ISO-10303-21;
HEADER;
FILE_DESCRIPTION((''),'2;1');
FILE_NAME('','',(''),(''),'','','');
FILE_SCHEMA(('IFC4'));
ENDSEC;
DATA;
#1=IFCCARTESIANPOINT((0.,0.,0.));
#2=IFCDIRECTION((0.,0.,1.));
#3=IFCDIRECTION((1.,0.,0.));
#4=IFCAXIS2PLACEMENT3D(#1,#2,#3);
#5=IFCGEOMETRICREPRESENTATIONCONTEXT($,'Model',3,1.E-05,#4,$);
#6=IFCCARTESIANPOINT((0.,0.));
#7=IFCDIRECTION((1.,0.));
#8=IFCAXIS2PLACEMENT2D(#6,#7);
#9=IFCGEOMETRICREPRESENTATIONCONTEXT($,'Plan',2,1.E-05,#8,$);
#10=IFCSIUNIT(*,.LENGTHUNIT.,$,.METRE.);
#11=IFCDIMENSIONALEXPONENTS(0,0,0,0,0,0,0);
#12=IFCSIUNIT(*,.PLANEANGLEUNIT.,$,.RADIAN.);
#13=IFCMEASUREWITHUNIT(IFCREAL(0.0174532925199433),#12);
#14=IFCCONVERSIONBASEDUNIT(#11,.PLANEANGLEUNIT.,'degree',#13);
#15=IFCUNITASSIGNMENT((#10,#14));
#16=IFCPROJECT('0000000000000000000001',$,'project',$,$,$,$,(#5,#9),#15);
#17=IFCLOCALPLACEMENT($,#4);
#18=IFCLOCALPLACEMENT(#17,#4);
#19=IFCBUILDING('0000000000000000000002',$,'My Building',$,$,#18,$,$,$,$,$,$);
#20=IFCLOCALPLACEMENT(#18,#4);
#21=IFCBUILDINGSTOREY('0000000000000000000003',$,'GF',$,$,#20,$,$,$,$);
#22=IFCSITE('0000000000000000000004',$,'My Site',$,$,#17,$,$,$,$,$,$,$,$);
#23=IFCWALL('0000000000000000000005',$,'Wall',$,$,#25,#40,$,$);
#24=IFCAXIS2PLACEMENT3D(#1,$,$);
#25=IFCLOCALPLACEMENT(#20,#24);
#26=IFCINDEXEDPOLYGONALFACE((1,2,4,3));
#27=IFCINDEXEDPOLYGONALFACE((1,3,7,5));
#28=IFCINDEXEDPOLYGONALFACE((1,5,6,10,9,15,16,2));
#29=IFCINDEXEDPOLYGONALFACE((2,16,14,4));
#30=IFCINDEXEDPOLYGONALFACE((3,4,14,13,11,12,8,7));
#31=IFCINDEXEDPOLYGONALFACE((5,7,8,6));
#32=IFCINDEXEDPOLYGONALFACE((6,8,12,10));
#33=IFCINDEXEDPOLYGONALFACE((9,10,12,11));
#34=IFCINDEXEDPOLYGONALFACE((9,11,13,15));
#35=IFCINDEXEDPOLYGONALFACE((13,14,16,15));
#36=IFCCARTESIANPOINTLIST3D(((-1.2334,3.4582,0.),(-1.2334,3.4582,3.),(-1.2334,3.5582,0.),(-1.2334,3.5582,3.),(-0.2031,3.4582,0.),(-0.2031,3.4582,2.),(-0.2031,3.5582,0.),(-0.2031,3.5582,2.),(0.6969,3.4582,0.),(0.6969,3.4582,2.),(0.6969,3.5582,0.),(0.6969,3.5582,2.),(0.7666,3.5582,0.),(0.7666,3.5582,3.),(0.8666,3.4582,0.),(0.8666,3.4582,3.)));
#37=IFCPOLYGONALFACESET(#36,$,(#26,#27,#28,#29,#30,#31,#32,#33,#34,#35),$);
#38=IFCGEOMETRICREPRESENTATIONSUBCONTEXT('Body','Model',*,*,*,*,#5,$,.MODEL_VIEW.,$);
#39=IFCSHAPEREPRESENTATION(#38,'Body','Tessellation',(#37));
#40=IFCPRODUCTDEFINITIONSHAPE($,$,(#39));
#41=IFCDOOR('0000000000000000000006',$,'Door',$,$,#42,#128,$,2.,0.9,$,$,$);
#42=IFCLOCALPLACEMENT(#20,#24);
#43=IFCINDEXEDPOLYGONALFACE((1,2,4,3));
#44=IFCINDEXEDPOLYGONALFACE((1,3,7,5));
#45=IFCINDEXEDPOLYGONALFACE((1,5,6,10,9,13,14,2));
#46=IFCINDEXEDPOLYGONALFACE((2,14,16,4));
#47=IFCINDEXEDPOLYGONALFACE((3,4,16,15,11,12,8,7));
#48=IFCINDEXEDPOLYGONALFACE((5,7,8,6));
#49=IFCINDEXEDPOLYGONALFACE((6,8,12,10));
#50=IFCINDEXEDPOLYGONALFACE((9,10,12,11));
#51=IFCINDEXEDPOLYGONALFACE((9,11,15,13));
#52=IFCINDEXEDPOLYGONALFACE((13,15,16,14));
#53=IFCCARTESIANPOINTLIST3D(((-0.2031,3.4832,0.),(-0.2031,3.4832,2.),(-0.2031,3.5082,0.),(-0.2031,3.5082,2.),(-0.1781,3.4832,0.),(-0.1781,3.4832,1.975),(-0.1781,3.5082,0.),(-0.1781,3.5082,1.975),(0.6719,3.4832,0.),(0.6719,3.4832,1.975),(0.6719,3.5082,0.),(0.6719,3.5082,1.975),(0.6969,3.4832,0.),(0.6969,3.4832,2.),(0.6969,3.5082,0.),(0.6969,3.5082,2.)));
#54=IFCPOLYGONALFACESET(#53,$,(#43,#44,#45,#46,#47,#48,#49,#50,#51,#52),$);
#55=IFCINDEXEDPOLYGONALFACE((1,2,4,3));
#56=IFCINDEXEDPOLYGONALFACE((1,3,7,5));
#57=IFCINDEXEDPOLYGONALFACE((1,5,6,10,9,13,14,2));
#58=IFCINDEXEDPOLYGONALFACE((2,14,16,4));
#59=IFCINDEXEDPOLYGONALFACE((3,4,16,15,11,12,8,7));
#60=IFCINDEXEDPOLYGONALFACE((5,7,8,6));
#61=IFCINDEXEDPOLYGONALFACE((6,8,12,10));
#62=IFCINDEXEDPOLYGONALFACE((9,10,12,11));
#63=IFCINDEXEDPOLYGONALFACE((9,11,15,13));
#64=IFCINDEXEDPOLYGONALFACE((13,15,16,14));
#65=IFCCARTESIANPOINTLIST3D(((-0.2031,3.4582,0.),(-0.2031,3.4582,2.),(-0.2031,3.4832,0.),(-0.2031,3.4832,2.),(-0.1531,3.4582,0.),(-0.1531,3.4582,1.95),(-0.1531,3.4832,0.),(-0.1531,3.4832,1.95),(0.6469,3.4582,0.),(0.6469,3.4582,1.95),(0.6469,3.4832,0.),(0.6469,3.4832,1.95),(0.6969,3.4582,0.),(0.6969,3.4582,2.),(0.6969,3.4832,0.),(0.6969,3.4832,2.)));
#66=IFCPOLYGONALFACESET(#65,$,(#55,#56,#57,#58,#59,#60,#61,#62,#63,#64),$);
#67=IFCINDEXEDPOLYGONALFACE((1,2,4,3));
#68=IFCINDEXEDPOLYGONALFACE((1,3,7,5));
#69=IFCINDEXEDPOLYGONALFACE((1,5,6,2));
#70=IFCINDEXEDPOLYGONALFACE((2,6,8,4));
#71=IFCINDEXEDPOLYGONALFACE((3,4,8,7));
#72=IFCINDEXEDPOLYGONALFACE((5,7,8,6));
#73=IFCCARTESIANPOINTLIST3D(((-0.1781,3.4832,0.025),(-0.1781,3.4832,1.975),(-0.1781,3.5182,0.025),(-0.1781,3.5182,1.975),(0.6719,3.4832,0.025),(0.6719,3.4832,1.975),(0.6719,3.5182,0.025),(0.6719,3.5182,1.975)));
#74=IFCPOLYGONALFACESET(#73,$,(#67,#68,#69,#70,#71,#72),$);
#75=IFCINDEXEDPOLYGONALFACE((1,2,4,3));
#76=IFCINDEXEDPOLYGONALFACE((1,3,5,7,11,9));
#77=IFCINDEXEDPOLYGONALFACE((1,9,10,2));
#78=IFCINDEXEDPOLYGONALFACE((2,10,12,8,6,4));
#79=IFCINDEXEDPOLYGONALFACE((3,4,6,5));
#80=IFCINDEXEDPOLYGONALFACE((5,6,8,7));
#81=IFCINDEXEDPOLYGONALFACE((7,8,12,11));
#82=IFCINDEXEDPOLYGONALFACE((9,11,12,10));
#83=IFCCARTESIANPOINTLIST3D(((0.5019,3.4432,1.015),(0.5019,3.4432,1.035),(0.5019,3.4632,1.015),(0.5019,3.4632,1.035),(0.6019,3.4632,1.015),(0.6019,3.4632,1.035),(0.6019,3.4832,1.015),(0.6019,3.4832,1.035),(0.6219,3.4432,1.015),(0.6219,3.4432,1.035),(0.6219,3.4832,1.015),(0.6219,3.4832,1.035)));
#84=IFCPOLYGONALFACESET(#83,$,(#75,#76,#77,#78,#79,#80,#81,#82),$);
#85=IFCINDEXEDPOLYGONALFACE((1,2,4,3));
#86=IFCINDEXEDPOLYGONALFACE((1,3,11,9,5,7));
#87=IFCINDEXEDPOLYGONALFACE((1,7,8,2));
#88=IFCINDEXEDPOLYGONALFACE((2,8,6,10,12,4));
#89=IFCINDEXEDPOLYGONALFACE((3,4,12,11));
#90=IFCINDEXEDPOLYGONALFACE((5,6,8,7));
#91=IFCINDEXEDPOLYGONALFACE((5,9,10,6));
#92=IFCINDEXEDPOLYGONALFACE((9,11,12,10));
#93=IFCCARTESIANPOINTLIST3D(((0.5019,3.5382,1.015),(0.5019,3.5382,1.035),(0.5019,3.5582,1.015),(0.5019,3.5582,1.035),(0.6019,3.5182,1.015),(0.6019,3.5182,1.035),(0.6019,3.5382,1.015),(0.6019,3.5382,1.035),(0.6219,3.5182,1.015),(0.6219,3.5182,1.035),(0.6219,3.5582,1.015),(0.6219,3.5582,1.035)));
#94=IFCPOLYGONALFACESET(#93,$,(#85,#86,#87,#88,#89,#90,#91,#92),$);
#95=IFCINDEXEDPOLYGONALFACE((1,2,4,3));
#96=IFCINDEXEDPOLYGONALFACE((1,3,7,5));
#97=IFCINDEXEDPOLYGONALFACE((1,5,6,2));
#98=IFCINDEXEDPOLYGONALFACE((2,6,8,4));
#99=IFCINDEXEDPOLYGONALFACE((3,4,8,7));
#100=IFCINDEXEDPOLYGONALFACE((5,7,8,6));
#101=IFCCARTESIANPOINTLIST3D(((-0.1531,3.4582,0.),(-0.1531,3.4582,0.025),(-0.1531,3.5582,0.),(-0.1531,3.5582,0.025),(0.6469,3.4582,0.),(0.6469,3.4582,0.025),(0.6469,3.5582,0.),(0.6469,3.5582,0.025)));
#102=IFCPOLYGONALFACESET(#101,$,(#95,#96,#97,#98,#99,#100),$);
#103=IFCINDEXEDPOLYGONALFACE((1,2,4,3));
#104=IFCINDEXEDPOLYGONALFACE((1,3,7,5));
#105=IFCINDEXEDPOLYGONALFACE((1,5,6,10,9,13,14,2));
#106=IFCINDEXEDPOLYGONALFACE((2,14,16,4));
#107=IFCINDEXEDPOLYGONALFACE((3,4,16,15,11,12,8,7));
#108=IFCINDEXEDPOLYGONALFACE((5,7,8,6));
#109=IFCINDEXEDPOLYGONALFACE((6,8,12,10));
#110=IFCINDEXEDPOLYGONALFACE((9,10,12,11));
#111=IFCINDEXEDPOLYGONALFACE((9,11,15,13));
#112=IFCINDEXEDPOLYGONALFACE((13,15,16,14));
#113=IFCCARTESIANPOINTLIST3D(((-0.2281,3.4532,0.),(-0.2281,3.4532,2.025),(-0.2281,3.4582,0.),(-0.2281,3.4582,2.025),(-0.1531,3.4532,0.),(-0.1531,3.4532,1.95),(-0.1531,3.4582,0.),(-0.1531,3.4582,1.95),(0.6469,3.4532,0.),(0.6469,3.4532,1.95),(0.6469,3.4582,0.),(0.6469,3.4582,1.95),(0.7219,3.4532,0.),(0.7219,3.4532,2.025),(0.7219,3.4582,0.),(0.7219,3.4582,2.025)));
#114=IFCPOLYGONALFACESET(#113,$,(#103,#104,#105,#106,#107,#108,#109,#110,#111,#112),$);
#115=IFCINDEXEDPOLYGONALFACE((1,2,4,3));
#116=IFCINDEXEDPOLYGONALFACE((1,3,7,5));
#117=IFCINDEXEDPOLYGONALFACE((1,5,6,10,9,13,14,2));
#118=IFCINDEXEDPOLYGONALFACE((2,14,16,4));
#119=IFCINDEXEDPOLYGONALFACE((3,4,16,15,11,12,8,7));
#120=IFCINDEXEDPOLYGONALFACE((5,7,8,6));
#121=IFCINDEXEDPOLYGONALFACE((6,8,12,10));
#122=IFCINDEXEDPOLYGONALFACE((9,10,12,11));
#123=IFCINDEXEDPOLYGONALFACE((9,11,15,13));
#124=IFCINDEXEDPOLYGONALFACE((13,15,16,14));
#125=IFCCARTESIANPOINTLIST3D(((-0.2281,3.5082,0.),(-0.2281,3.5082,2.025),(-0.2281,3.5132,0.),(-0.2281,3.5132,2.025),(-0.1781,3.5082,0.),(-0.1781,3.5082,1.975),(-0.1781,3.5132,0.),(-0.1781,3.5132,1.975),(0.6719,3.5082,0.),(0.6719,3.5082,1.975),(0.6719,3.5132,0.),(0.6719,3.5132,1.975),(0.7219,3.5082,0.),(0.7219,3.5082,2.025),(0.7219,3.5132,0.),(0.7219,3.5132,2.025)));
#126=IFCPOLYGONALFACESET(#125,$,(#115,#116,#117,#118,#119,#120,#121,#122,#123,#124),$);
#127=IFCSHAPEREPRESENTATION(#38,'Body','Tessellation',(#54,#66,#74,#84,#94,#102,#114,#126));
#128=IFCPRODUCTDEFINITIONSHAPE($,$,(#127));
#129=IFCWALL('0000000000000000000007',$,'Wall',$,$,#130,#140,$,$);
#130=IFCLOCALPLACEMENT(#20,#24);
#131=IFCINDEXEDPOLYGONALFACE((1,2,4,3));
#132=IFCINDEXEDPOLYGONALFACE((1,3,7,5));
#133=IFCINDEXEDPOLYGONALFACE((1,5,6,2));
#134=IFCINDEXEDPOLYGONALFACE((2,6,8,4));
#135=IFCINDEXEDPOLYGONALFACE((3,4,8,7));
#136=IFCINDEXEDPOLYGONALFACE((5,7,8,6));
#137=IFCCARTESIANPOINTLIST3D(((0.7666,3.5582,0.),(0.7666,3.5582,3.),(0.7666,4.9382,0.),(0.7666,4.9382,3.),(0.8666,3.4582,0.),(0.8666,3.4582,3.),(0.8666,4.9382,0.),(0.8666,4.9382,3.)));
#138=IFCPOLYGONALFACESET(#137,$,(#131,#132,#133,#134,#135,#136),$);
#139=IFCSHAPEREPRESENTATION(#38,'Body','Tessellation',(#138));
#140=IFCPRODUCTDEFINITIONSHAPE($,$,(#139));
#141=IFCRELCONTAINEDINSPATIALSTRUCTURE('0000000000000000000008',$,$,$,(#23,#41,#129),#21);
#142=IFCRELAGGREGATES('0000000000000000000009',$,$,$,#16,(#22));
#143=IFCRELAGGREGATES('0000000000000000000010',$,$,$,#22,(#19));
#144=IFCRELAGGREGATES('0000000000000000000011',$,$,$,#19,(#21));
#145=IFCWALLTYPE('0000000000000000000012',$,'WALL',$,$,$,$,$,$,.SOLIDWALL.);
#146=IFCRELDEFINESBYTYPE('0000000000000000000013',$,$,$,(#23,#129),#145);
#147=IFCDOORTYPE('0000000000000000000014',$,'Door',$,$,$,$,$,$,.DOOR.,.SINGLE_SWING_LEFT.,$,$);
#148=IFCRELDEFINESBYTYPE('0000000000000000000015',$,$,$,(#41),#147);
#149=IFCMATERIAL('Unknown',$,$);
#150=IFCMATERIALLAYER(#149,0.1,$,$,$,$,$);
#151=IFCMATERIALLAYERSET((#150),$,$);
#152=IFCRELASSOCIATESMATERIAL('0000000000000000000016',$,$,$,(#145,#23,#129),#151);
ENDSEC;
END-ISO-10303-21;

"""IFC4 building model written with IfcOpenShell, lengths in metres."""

from ifc_helpers import new_model, entity, si_unit, converted_unit, frame, origin_with_axes, origin_2d_with_axis, place, context, subcontext, project, spatial, line, indexed_curve, outline, extrude, shape, source, transform, mapped, material, layer, layer_set, layer_usage, type_object, type_shapes, element, fill, save


model = new_model("IFC4")

# Units and contexts
model_context = context("Model", 3, precision=1e-05, world=origin_with_axes())
plan_context = context("Plan", 2, precision=1e-05, world=origin_2d_with_axis())
body_context_1 = subcontext(model_context, "Body", "Model", "MODEL_VIEW")
body_context_2 = subcontext(plan_context, "Body", "Plan", "PLAN_VIEW")
ifc_project = project(units=[si_unit("LENGTHUNIT", "METRE"), converted_unit("PLANEANGLEUNIT", "degree", entity("IfcReal", 0.0174532925199433), si_unit("PLANEANGLEUNIT", "RADIAN"), dimensions=[0, 0, 0, 0, 0, 0, 0])], contexts=[model_context, plan_context])

# Site, building, storey
site_placement = place(None, origin_with_axes())
site = spatial("IfcSite", under=ifc_project, at=site_placement, Name="My Site")
building_placement = place(site_placement, origin_with_axes())
building = spatial("IfcBuilding", under=site, at=building_placement, Name="My Building")
storey_placement = place(building_placement, origin_with_axes())
storey = spatial("IfcBuildingStorey", under=building, at=storey_placement, Name="GF")

# Shared definitions
ifc_material = material(Name="Unknown")

# Shared definitions
ifc_layer_1 = layer(ifc_material, 0.1)
ifc_layer_set_1 = layer_set([ifc_layer_1])
wall_type = type_object("IfcWallType", Name="WALL", PredefinedType="SOLIDWALL", material=ifc_layer_set_1)
shared_shape_1 = source(origin_with_axes(), body_context_1, "Body", "SweptSolid", [
    extrude(outline(indexed_curve([(0.0, 0.0), (0.9, 0.0), (0.9, 2.0), (0.0, 2.0)], segments=[line(1, 2, 3, 4, 1)])), frame((0.0, -0.6, 0.0), z_axis=(0.0, -1.0, 0.0), x_axis=(1.0, 0.0, 0.0)), (0.0, 0.0, -1.0), 1.2),
])
door_type = type_object("IfcDoorType", Name="Door", OperationType="SINGLE_SWING_LEFT", PredefinedType="DOOR")
shared_shape_2 = source(origin_with_axes(), body_context_1, "Body", "SweptSolid", [
    extrude(outline(indexed_curve([(0.0, 0.0), (0.0, 2.0), (0.9, 2.0), (0.9, 0.0), (0.875, 0.0), (0.875, 1.975), (0.025, 1.975), (0.025, 0.0)], segments=[line(1, 2, 3, 4, 5, 6, 7, 8, 1)])), frame((0.0, 0.025, 0.0), z_axis=(0.0, -1.0, 0.0), x_axis=(1.0, 0.0, 0.0)), (0.0, 0.0, -1.0), 0.025),
    extrude(outline(indexed_curve([(0.0, 0.0), (0.0, 2.0), (0.9, 2.0), (0.9, 0.0), (0.85, 0.0), (0.85, 1.95), (0.05, 1.95), (0.05, 0.0)], segments=[line(1, 2, 3, 4, 5, 6, 7, 8, 1)])), frame((0.0, 0.0, 0.0), z_axis=(0.0, -1.0, 0.0), x_axis=(1.0, 0.0, 0.0)), (0.0, 0.0, -1.0), 0.025),
    extrude(outline(indexed_curve([(0.0, 0.0), (0.85, 0.0), (0.85, 0.035), (0.0, 0.035)], segments=[line(1, 2, 3, 4, 1)])), frame((0.025, 0.025, 0.025), z_axis=(0.0, 0.0, 1.0), x_axis=(1.0, 0.0, 0.0)), (0.0, 0.0, 1.0), 1.95),
    extrude(outline(indexed_curve([(0.0, 0.0), (0.0, -0.04), (-0.12, -0.04), (-0.12, -0.02), (-0.02, -0.02), (-0.02, 0.0)], segments=[line(1, 2, 3, 4, 5, 6, 1)])), frame((0.825, 0.025, 1.015), z_axis=(0.0, 0.0, 1.0), x_axis=(1.0, 0.0, 0.0)), (0.0, 0.0, 1.0), 0.02),
    extrude(outline(indexed_curve([(0.0, 0.0), (0.0, 0.04), (-0.12, 0.04), (-0.12, 0.02), (-0.02, 0.02), (-0.02, 0.0)], segments=[line(1, 2, 3, 4, 5, 6, 1)])), frame((0.825, 0.06, 1.015), z_axis=(0.0, 0.0, 1.0), x_axis=(1.0, 0.0, 0.0)), (0.0, 0.0, 1.0), 0.02),
    extrude(outline(indexed_curve([(0.0, 0.0), (0.8, 0.0), (0.8, 0.1), (0.0, 0.1)], segments=[line(1, 2, 3, 4, 1)])), frame((0.05, 0.0, 0.0), z_axis=(0.0, 0.0, 1.0), x_axis=(1.0, 0.0, 0.0)), (0.0, 0.0, 1.0), 0.025),
    extrude(outline(indexed_curve([(0.0, 0.0), (0.0, 2.025), (0.95, 2.025), (0.95, 0.0), (0.875, 0.0), (0.875, 1.95), (0.075, 1.95), (0.075, 0.0)], segments=[line(1, 2, 3, 4, 5, 6, 7, 8, 1)])), frame((-0.025, -0.005, 0.0), z_axis=(0.0, -1.0, 0.0), x_axis=(1.0, 0.0, 0.0)), (0.0, 0.0, -1.0), 0.005),
    extrude(outline(indexed_curve([(0.0, 0.0), (0.0, 2.025), (0.95, 2.025), (0.95, 0.0), (0.9, 0.0), (0.9, 1.975), (0.05, 1.975), (0.05, 0.0)], segments=[line(1, 2, 3, 4, 5, 6, 7, 8, 1)])), frame((-0.025, 0.05, 0.0), z_axis=(0.0, -1.0, 0.0), x_axis=(1.0, 0.0, 0.0)), (0.0, 0.0, -1.0), 0.005),
])
shared_shape_3 = source(origin_with_axes(), body_context_2, "Body", "Curve2D", [
    entity("IfcIndexedPolyCurve", entity("IfcCartesianPointList2D", [[0.0, 0.0], [0.0, 0.05], [0.025, 0.05], [0.025, 0.025], [0.05, 0.025], [0.05, 0.0]]), [entity("IfcLineIndex", [1, 2, 3, 4, 5, 6, 1])]),
    entity("IfcIndexedPolyCurve", entity("IfcCartesianPointList2D", [[0.9, 0.0], [0.9, 0.05], [0.875, 0.05], [0.875, 0.025], [0.85, 0.025], [0.85, 0.0]]), [entity("IfcLineIndex", [1, 2, 3, 4, 5, 6, 1])]),
    entity("IfcTrimmedCurve", entity("IfcEllipse", entity("IfcAxis2Placement2D", entity("IfcCartesianPoint", [0.06, 0.05]), entity("IfcDirection", [1.0, 0.0])), 0.815, 0.85), [entity("IfcCartesianPoint", [0.875, 0.05])], [entity("IfcCartesianPoint", [0.06, 0.9])], True, "CARTESIAN"),
    entity("IfcIndexedPolyCurve", entity("IfcCartesianPointList2D", [[0.025, 0.05], [0.06, 0.05], [0.06, 0.9], [0.025, 0.9]]), [entity("IfcLineIndex", [1, 2, 3, 4, 1])]),
])
type_shapes(door_type, [shared_shape_2, shared_shape_3])

# Wall, opening, door
ifc_layer_usage_1 = layer_usage(ifc_layer_set_1, "AXIS2", "POSITIVE", 0.0)
wall_1_placement = place(storey_placement, frame((-1.2334, 3.4582, 0.0), z_axis=(0.0, 0.0, 1.0), x_axis=(1.0, 0.0, 0.0)))
wall_1 = element("IfcWall", 1, at=wall_1_placement, inside=storey, type_object=wall_type, material=ifc_layer_usage_1, Name="Wall", context=body_context_1, shape_type="SweptSolid", body=[
    extrude(outline(indexed_curve([(0.0, 0.0), (0.0, 0.1), (2.0, 0.1), (2.1, 0.0)], segments=[line(1, 2, 3, 4, 1)])), origin_with_axes(), (0.0, 0.0, 1.0), 3.0),
])
opening_1_placement = place(wall_1_placement, frame((1.0303, 0.0, 0.0), z_axis=(0.0, 0.0, 1.0), x_axis=(1.0, 0.0, 0.0)))
opening_1 = element("IfcOpeningElement", 2, at=opening_1_placement, cuts=wall_1, PredefinedType="OPENING", context=body_context_1, shape_type="MappedRepresentation", body=[
    mapped(shared_shape_1, transform((0.0, 0.0, 0.0), x_axis=(1.0, 0.0, 0.0), y_axis=(0.0, 1.0, 0.0), z_axis=(0.0, 0.0, 1.0), scale=1.0)),
])
door_1_placement = place(opening_1_placement, origin_with_axes())
door_1 = element("IfcDoor", 3, at=door_1_placement, inside=storey, type_object=door_type, Name="Door", OverallHeight=2.0, OverallWidth=0.9, shapes=[
    shape(body_context_1, "Body", "MappedRepresentation", [mapped(shared_shape_2, transform((0.0, 0.0, 0.0), x_axis=(1.0, 0.0, 0.0), y_axis=(0.0, 1.0, 0.0), z_axis=(0.0, 0.0, 1.0), scale=1.0))]),
    shape(body_context_2, "Body", "MappedRepresentation", [mapped(shared_shape_3, transform((0.0, 0.0, 0.0), x_axis=(1.0, 0.0, 0.0), y_axis=(0.0, 1.0, 0.0), z_axis=(0.0, 0.0, 1.0), scale=1.0))]),
])
fill(opening_1, door_1)

# Wall
ifc_layer_usage_2 = layer_usage(ifc_layer_set_1, "AXIS2", "POSITIVE", 0.0)
wall_2_placement = place(storey_placement, frame((0.8666, 3.4582, 0.0), z_axis=(0.0, 0.0, 1.0), x_axis=(0.0, 1.0, 0.0)))
element("IfcWall", 4, at=wall_2_placement, inside=storey, type_object=wall_type, material=ifc_layer_usage_2, Name="Wall", context=body_context_1, shape_type="SweptSolid", body=[
    extrude(outline(indexed_curve([(0.0, 0.0), (0.1, 0.1), (1.48, 0.1), (1.48, 0.0)], segments=[line(1, 2, 3, 4, 1)])), origin_with_axes(), (0.0, 0.0, 1.0), 3.0),
])

save(model, "model.ifc")
